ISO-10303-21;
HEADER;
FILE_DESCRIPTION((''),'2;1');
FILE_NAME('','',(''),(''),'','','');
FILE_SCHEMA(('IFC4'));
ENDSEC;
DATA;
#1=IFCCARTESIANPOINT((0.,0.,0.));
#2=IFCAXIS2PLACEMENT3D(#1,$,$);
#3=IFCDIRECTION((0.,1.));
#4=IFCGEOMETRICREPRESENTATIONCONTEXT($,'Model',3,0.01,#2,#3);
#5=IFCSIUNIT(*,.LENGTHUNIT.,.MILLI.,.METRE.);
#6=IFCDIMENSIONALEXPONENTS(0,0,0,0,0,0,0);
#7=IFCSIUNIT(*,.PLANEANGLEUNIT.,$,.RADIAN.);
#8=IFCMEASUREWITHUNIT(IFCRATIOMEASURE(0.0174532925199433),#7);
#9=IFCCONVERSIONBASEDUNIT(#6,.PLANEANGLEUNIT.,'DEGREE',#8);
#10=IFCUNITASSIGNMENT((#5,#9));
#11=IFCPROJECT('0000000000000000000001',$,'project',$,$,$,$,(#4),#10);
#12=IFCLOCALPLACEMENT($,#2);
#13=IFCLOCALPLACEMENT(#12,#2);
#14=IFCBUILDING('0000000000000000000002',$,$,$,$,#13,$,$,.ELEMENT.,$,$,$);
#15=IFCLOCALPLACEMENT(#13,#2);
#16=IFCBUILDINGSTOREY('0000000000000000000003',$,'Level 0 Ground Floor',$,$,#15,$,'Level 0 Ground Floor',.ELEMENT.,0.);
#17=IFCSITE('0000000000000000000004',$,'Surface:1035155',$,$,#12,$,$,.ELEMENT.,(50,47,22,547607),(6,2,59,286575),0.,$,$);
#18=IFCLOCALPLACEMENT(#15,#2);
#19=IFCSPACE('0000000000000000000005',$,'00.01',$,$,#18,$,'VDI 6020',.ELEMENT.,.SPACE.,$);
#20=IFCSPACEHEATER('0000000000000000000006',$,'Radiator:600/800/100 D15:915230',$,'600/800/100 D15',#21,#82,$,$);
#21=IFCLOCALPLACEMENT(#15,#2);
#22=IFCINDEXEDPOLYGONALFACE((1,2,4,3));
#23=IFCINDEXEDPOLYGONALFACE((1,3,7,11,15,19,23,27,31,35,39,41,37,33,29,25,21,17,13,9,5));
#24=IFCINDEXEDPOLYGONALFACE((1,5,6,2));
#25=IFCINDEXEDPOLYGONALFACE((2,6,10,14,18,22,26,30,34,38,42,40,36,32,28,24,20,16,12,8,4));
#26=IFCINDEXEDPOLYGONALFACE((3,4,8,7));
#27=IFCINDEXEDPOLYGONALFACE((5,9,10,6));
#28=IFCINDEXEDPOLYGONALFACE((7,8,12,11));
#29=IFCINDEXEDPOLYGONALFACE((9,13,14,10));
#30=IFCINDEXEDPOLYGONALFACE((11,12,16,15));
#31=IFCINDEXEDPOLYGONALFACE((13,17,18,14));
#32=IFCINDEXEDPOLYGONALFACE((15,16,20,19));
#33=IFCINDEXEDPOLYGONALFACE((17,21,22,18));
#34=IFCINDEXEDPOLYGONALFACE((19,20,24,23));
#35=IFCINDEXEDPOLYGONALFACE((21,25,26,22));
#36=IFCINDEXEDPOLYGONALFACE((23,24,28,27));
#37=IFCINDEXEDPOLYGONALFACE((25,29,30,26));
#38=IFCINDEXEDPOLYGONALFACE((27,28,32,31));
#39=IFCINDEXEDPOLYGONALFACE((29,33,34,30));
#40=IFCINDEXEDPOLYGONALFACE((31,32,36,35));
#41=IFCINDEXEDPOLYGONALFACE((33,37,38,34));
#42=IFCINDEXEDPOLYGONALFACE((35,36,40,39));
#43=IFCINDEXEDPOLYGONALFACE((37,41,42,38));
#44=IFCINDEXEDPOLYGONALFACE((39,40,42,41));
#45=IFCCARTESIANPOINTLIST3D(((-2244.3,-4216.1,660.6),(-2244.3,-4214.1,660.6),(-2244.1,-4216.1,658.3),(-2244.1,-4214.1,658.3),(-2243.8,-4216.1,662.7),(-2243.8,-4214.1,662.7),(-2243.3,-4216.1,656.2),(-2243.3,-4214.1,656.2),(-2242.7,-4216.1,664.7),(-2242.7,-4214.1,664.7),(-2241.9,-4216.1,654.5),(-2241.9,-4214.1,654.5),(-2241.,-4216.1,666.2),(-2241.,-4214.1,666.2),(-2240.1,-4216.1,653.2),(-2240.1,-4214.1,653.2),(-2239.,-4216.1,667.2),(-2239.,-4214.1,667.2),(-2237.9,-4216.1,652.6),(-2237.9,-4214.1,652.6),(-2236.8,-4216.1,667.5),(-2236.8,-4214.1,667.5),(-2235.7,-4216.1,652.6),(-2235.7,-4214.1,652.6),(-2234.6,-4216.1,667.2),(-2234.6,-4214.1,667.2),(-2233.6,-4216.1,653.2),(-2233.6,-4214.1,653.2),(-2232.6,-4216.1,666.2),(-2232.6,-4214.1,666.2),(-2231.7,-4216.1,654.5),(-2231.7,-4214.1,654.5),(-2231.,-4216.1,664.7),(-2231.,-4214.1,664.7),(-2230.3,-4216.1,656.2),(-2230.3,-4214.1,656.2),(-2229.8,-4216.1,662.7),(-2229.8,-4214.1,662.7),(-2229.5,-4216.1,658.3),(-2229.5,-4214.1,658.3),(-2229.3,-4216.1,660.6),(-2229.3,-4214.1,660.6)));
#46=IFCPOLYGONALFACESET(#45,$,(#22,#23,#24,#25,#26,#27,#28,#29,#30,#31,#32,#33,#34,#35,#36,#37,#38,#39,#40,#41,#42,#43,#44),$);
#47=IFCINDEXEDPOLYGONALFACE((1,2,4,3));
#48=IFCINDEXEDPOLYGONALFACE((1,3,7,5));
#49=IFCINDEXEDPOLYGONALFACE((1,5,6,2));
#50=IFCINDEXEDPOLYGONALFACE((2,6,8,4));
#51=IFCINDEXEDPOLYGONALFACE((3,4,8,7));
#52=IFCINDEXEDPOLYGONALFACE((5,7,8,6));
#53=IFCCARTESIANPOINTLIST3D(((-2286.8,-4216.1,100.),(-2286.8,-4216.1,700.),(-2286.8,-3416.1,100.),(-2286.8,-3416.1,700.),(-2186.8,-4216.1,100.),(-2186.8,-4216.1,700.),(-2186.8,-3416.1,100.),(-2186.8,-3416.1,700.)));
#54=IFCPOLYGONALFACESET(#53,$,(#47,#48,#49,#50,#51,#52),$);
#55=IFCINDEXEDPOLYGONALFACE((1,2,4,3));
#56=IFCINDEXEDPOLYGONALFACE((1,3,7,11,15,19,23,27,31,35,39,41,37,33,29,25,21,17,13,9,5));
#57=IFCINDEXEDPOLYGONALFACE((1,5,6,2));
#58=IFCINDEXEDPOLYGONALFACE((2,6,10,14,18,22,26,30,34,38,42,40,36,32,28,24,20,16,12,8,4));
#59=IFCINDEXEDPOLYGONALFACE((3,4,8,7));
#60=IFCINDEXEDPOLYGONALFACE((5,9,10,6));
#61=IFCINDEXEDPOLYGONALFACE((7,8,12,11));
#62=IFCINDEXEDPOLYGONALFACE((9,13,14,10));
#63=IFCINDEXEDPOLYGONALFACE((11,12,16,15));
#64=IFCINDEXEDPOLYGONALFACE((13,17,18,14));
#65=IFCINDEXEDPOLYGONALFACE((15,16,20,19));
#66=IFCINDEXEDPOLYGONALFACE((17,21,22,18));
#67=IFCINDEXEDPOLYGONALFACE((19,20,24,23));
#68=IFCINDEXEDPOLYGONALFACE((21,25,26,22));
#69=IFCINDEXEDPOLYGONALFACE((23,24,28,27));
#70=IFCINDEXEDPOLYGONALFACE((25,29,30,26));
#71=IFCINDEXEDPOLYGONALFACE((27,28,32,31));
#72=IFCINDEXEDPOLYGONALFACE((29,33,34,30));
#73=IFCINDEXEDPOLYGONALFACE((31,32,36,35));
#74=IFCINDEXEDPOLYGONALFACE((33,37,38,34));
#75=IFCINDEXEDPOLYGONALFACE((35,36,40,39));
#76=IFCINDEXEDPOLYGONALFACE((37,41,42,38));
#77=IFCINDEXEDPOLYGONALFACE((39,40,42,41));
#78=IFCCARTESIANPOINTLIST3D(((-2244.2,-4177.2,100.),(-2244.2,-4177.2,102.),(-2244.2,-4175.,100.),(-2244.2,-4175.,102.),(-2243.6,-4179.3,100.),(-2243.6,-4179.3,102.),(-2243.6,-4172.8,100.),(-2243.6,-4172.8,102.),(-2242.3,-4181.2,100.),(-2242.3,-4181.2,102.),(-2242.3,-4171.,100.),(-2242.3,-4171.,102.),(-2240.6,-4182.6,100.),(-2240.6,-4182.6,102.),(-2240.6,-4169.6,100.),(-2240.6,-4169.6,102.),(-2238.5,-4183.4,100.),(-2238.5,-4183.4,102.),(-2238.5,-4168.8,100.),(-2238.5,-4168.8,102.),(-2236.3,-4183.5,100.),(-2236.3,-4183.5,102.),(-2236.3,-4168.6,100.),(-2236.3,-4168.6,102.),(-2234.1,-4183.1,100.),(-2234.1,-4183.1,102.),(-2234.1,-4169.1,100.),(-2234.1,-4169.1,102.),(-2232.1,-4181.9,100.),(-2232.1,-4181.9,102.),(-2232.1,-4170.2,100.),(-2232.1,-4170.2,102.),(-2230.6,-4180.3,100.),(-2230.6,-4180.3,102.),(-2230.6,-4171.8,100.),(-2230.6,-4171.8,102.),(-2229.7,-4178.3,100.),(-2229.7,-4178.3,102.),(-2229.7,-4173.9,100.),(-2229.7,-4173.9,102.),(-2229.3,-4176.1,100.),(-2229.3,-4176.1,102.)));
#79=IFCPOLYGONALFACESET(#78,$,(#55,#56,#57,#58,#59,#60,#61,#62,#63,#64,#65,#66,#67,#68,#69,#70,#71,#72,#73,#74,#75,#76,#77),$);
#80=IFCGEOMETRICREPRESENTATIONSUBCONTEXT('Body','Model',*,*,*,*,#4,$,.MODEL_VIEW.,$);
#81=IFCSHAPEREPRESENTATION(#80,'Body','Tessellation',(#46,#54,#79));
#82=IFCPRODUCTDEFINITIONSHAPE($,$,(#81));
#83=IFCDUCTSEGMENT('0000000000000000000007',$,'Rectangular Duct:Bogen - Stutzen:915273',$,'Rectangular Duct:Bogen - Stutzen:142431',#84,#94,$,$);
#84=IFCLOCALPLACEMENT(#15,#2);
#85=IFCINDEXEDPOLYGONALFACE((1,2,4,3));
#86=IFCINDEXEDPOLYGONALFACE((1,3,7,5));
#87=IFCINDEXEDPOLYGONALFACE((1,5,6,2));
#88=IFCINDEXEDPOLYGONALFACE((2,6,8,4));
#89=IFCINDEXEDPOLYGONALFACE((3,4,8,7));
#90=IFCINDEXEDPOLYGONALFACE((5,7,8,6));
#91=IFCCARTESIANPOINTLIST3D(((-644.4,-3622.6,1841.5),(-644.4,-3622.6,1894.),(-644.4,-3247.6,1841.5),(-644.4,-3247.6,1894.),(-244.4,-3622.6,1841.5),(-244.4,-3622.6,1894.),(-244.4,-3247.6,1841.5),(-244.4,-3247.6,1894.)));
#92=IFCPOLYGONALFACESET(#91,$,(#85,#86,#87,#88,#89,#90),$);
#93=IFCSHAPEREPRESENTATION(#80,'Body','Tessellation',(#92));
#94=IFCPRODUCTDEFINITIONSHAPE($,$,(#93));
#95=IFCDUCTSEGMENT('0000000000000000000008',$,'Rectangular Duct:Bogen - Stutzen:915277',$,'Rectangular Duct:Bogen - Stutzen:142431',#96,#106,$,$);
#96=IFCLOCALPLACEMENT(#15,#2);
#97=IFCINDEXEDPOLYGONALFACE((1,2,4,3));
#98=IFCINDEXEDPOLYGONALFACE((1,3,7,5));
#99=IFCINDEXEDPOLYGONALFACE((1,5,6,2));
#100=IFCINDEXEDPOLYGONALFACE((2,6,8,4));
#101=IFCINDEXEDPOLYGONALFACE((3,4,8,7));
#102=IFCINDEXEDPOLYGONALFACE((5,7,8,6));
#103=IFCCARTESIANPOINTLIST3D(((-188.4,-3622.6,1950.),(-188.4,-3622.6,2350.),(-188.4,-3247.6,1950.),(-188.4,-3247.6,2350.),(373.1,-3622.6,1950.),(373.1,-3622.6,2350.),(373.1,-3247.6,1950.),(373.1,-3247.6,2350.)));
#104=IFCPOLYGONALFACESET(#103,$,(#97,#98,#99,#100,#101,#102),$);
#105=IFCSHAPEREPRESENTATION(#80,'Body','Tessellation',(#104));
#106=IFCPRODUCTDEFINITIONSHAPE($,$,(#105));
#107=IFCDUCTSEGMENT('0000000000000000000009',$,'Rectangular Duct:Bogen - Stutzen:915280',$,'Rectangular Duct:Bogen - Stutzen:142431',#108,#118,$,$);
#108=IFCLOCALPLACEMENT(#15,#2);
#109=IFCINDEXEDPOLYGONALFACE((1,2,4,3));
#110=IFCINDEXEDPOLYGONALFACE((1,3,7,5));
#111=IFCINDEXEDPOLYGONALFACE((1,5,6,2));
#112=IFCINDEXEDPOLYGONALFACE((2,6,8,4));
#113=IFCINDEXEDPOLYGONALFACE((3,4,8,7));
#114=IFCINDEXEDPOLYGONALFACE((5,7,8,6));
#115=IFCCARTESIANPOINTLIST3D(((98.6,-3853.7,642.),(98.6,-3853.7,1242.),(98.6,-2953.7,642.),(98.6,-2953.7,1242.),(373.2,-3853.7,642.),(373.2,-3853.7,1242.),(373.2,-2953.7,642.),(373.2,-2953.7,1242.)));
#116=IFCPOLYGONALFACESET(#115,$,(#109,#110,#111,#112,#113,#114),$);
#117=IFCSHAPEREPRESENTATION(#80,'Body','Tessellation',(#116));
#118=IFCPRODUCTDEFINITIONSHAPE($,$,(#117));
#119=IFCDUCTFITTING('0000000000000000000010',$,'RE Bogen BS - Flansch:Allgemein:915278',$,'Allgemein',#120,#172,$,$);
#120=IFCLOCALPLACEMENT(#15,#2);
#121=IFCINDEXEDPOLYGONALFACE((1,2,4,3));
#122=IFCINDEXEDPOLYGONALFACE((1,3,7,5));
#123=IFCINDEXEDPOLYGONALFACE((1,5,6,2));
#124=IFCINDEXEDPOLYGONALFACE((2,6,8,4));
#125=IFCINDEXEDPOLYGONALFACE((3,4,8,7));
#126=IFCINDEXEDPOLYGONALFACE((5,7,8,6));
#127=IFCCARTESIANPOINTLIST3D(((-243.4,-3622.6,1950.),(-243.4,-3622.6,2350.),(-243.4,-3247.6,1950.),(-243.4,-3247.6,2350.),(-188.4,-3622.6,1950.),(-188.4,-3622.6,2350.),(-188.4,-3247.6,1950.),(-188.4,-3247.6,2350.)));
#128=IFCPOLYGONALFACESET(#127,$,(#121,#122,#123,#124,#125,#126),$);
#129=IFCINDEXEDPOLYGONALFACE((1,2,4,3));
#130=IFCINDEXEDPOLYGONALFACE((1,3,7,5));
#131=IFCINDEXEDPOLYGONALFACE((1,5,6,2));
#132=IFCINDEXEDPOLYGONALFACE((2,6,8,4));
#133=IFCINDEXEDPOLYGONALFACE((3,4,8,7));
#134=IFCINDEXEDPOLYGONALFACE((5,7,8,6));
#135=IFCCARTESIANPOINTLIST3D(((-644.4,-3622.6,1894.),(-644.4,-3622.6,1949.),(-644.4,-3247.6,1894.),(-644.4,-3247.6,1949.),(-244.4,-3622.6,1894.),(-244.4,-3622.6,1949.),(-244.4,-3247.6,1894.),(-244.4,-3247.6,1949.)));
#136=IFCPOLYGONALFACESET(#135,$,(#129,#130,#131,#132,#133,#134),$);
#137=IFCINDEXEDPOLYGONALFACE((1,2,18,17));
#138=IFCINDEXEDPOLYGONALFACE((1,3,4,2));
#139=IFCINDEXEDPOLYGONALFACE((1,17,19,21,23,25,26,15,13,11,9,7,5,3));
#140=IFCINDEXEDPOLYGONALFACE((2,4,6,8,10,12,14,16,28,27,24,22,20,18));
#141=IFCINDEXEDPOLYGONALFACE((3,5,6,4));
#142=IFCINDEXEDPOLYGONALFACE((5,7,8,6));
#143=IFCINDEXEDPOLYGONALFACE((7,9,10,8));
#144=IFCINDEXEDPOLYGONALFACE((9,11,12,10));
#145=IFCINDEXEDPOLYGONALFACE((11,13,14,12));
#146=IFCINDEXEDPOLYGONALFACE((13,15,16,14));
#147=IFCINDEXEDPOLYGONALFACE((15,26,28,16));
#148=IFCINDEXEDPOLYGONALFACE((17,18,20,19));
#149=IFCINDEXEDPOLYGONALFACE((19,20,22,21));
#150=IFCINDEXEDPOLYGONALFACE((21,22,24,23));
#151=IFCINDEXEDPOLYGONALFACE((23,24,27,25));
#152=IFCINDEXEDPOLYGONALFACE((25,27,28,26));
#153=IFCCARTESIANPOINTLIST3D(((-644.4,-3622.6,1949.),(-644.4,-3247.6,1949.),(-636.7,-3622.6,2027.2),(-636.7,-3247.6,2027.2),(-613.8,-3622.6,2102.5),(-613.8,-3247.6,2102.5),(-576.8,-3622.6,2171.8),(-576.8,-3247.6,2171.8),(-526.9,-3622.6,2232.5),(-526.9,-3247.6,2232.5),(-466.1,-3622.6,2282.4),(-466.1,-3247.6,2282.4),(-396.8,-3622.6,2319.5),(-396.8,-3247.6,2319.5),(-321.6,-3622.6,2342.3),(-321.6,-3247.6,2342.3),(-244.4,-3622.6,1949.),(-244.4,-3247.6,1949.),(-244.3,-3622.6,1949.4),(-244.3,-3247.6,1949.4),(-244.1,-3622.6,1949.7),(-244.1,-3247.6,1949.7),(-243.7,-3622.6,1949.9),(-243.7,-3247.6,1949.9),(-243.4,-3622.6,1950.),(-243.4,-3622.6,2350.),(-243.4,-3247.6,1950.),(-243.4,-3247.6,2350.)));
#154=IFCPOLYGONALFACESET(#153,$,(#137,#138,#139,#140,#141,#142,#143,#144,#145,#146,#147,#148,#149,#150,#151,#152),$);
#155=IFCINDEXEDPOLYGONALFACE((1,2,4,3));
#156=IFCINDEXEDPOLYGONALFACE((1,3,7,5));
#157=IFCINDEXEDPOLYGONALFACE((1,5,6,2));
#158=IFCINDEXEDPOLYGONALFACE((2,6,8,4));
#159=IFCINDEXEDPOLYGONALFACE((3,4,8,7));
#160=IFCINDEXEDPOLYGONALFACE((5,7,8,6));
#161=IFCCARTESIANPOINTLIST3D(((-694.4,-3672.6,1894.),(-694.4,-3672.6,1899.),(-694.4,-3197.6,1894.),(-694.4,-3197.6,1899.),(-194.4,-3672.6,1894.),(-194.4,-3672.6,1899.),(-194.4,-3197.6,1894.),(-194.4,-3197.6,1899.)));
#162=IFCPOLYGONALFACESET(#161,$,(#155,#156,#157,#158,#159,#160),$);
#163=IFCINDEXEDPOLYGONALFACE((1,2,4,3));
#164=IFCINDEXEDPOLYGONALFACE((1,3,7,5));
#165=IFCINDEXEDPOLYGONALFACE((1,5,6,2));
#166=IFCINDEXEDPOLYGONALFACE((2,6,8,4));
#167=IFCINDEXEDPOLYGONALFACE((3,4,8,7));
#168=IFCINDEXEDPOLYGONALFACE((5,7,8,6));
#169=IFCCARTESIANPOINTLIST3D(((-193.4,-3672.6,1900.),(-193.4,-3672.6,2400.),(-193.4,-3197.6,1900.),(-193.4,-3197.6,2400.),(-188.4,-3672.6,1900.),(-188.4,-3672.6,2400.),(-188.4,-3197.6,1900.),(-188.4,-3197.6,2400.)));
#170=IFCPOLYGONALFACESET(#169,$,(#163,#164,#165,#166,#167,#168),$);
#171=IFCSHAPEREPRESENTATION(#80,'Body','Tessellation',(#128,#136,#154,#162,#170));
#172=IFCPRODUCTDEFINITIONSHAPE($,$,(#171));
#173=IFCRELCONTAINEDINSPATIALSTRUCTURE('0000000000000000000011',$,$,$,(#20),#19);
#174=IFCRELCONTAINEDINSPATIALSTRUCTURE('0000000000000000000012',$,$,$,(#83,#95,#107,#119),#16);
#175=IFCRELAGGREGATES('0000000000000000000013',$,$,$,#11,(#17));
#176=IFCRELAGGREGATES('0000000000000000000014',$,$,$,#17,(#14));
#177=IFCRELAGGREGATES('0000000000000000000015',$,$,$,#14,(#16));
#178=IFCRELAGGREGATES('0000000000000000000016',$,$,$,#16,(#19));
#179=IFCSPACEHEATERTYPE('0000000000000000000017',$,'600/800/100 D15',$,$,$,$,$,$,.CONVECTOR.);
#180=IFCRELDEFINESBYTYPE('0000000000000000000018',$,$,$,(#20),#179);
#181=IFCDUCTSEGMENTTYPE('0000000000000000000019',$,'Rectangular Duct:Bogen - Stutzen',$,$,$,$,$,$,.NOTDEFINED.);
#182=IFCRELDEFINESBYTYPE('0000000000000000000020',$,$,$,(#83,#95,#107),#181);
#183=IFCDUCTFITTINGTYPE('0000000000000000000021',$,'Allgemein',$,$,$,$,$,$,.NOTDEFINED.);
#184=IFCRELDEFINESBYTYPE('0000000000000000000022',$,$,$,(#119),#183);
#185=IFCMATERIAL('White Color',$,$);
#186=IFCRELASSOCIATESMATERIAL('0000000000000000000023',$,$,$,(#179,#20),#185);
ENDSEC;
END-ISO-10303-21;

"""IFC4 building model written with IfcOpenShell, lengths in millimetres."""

from ifc_helpers import new_model, entity, si_unit, converted_unit, direction, frame, frame_2d, origin, origin_2d_with_axis, place, context, subcontext, project, spatial, polyline, circle_curve, parameter, trimmed, segment, composite_curve, rectangle, circle, outline, extrude, source, transform, mapped, material, type_object, type_shapes, element, save


model = new_model("IFC4")

# Units and contexts
model_context = context("Model", 3, precision=0.01, world=origin(), true_north=direction((0.0, 1.0)))
body_context = subcontext(model_context, "Body", "Model", "MODEL_VIEW")
ifc_project = project(units=[si_unit("LENGTHUNIT", "METRE", prefix="MILLI"), converted_unit("PLANEANGLEUNIT", "DEGREE", entity("IfcRatioMeasure", 0.0174532925199433), si_unit("PLANEANGLEUNIT", "RADIAN"), dimensions=[0, 0, 0, 0, 0, 0, 0])], contexts=[model_context])

# Site, building, storey
site_placement = place(None, origin())
site = spatial("IfcSite", under=ifc_project, at=site_placement, Name="Surface:1035155", CompositionType="ELEMENT", RefLatitude=(50, 47, 22, 547607), RefLongitude=(6, 2, 59, 286575), RefElevation=0.0)
building_placement = place(site_placement, origin())
building = spatial("IfcBuilding", under=site, at=building_placement, CompositionType="ELEMENT")
storey_placement = place(building_placement, origin())
storey = spatial("IfcBuildingStorey", under=building, at=storey_placement, Name="Level 0 Ground Floor", LongName="Level 0 Ground Floor", CompositionType="ELEMENT", Elevation=0.0)

# Shared definitions
space_placement = place(storey_placement, origin())
space = spatial("IfcSpace", under=storey, at=space_placement, Name="00.01", LongName="VDI 6020", CompositionType="ELEMENT", PredefinedType="SPACE")

# Space heater
ifc_material_1 = material(Name="White Color")
space_heater_type = type_object("IfcSpaceHeaterType", Name="600/800/100 D15", PredefinedType="CONVECTOR", material=ifc_material_1)
shared_shape_1 = source(origin(), body_context, "Body", "SweptSolid", [
    extrude(circle(Radius=7.5, at=frame_2d((0.0, 0.0), x_axis=(1.0, 0.0))), frame((798.0, 50.0, 560.0), z_axis=(1.0, 0.0, 0.0), x_axis=(0.0, 0.0, 1.0)), (0.0, 0.0, 1.0), 2.0),
    extrude(rectangle(XDim=100.0, YDim=800.0, at=frame_2d((0.0, 0.0), x_axis=(1.0, 0.0))), frame((400.0, 50.0, 0.0), z_axis=(0.0, 0.0, 1.0), x_axis=(0.0, 1.0, 0.0)), (0.0, 0.0, 1.0), 600.0),
    extrude(circle(Radius=7.5, at=frame_2d((0.0, 0.0), x_axis=(1.0, 0.0))), frame((760.0, 50.0, 0.0), z_axis=(0.0, 0.0, 1.0), x_axis=(0.0, 1.0, 0.0)), (0.0, 0.0, 1.0), 2.0),
])
type_shapes(space_heater_type, [shared_shape_1])
space_heater_placement = place(space_placement, frame((-2286.8, -3416.1, 100.0), z_axis=(0.0, 0.0, 1.0), x_axis=(0.0, -1.0, 0.0)))
element("IfcSpaceHeater", 1, at=space_heater_placement, inside=space, type_object=space_heater_type, material=ifc_material_1, Name="Radiator:600/800/100 D15:915230", ObjectType="600/800/100 D15", context=body_context, shape_type="MappedRepresentation", body=[
    mapped(shared_shape_1, transform((0.0, 0.0, 0.0), scale=1.0)),
])

# Duct segments
duct_segment_type = type_object("IfcDuctSegmentType", Name="Rectangular Duct:Bogen - Stutzen", PredefinedType="NOTDEFINED")
duct_segment_1_placement = place(storey_placement, frame((-644.4, -3622.6, 1841.5)))
element("IfcDuctSegment", 2, at=duct_segment_1_placement, inside=storey, type_object=duct_segment_type, Name="Rectangular Duct:Bogen - Stutzen:915273", ObjectType="Rectangular Duct:Bogen - Stutzen:142431", context=body_context, shape_type="SweptSolid", body=[
    extrude(rectangle(XDim=375.0, YDim=400.0, at=origin_2d_with_axis()), frame((200.0, 187.5, 0.0), z_axis=(0.0, 0.0, 1.0), x_axis=(0.0, 1.0, 0.0)), (0.0, 0.0, 1.0), 52.5),
])
duct_segment_2_placement = place(storey_placement, frame((-188.4, -3622.6, 1950.0)))
element("IfcDuctSegment", 3, at=duct_segment_2_placement, inside=storey, type_object=duct_segment_type, Name="Rectangular Duct:Bogen - Stutzen:915277", ObjectType="Rectangular Duct:Bogen - Stutzen:142431", context=body_context, shape_type="SweptSolid", body=[
    extrude(rectangle(XDim=561.5, YDim=375.0, at=origin_2d_with_axis()), frame((280.8, 187.5, 0.0)), (0.0, 0.0, 1.0), 400.0),
])
duct_segment_3_placement = place(storey_placement, frame((98.6, -3853.7, 642.0)))
element("IfcDuctSegment", 4, at=duct_segment_3_placement, inside=storey, type_object=duct_segment_type, Name="Rectangular Duct:Bogen - Stutzen:915280", ObjectType="Rectangular Duct:Bogen - Stutzen:142431", context=body_context, shape_type="SweptSolid", body=[
    extrude(rectangle(XDim=274.6, YDim=900.0, at=frame_2d((0.0, 0.0), x_axis=(1.0, 0.0))), frame((137.3, 450.0, 0.0)), (0.0, 0.0, 1.0), 600.0),
])

# Duct fitting
duct_fitting_type = type_object("IfcDuctFittingType", Name="Allgemein", PredefinedType="NOTDEFINED")
shared_shape_2 = source(origin(), body_context, "Body", "SweptSolid", [
    extrude(rectangle(XDim=55.0, YDim=400.0, at=frame_2d((0.0, 0.0), x_axis=(1.0, 0.0))), frame((0.0, 228.5, -187.5), z_axis=(0.0, 0.0, 1.0), x_axis=(0.0, 1.0, 0.0)), (0.0, 0.0, 1.0), 375.0),
    extrude(rectangle(XDim=400.0, YDim=55.0, at=frame_2d((0.0, 0.0), x_axis=(1.0, 0.0))), frame((-228.5, 0.0, -187.5), z_axis=(0.0, 0.0, 1.0), x_axis=(0.0, -1.0, 0.0)), (0.0, 0.0, 1.0), 375.0),
    extrude(outline(composite_curve([segment(polyline([(-300.5, -100.5), (99.5, -100.5)]), True, "CONTINUOUS"), segment(trimmed(circle_curve(frame_2d((100.5, -100.5), x_axis=(0.0, 1.0)), 1.0), [parameter(0.0)], [parameter(90.0)], True, "PARAMETER"), False, "CONTINUOUS"), segment(polyline([(100.5, -99.5), (100.5, 300.5)]), True, "CONTINUOUS"), segment(trimmed(circle_curve(frame_2d((100.5, -100.5), x_axis=(0.0, 1.0)), 401.0), [parameter(0.0)], [parameter(90.0)], True, "PARAMETER"), True, "CONTINUOUS")], self_intersect=False)), frame((-100.5, 100.5, -187.5), z_axis=(0.0, 0.0, 1.0), x_axis=(-1.0, 0.0, 0.0)), (0.0, 0.0, 1.0), 375.0),
    extrude(rectangle(XDim=5.0, YDim=500.0, at=frame_2d((0.0, 0.0), x_axis=(1.0, 0.0))), frame((-253.5, 0.0, -237.5)), (0.0, 0.0, 1.0), 475.0),
    extrude(rectangle(XDim=5.0, YDim=500.0, at=origin_2d_with_axis()), frame((0.0, 253.5, -237.5), z_axis=(0.0, 0.0, 1.0), x_axis=(0.0, 1.0, 0.0)), (0.0, 0.0, 1.0), 475.0),
])
type_shapes(duct_fitting_type, [shared_shape_2])
duct_fitting_placement = place(storey_placement, frame((-444.4, -3435.1, 2150.0), z_axis=(0.0, 1.0, 0.0), x_axis=(0.0, 0.0, 1.0)))
element("IfcDuctFitting", 5, at=duct_fitting_placement, inside=storey, type_object=duct_fitting_type, Name="RE Bogen BS - Flansch:Allgemein:915278", ObjectType="Allgemein", context=body_context, shape_type="MappedRepresentation", body=[
    mapped(shared_shape_2, transform((0.0, 0.0, 0.0), scale=1.0)),
])

save(model, "model.ifc")
